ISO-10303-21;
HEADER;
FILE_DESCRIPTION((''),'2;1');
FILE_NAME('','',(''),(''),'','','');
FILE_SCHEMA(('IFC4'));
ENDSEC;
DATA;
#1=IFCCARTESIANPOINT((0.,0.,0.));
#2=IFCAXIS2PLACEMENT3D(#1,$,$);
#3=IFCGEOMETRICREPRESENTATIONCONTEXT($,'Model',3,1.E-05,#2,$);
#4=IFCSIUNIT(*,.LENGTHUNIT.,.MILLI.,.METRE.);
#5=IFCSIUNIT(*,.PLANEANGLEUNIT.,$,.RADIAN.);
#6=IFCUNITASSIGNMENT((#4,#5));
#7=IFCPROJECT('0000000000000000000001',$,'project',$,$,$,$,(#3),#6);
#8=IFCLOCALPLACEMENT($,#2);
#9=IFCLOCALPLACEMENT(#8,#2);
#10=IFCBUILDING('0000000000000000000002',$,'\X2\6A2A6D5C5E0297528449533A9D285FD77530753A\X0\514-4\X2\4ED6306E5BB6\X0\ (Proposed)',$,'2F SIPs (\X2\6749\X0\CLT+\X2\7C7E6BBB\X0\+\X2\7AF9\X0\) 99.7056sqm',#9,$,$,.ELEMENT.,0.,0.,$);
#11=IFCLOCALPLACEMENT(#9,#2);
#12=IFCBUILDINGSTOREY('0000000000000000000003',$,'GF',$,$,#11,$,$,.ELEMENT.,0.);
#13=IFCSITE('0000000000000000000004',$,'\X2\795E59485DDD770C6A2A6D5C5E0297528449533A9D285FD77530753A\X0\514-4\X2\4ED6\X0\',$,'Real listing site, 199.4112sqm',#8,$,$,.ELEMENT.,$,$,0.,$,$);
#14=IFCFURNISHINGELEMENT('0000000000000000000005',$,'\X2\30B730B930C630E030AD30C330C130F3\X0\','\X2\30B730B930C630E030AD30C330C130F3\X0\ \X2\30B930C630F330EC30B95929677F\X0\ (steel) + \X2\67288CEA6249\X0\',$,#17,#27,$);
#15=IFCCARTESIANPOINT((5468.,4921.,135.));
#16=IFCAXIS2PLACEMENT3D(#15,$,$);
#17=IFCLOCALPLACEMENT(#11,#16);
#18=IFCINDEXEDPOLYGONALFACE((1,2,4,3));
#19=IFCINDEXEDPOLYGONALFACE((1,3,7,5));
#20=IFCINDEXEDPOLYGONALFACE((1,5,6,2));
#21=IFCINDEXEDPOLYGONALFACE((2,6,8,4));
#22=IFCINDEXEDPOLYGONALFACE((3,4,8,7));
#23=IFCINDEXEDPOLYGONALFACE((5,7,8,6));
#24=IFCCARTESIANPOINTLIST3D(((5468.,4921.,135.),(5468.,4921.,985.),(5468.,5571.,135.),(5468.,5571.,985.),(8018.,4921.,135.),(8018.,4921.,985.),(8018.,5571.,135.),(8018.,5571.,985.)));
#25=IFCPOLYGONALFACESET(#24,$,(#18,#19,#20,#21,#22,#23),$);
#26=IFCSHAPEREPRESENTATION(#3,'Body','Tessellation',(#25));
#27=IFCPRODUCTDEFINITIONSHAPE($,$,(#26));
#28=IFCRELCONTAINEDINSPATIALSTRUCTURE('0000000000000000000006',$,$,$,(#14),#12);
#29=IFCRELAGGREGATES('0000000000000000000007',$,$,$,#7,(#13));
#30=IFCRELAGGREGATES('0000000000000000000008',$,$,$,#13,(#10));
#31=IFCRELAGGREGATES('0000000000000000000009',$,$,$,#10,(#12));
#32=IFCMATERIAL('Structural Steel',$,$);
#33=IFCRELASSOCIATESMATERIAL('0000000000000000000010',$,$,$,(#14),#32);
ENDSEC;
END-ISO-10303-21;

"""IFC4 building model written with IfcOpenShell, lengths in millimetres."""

from ifc_helpers import new_model, si_unit, frame, frame_2d, origin, place, context, project, spatial, rectangle, extrude, material, element, save


model = new_model("IFC4")

# Units and contexts
model_context = context("Model", 3, precision=1e-05, world=origin())
ifc_project = project(units=[si_unit("LENGTHUNIT", "METRE", prefix="MILLI"), si_unit("PLANEANGLEUNIT", "RADIAN")], contexts=[model_context])

# Site, building, storey
site_placement = place(None, origin())
site = spatial("IfcSite", under=ifc_project, at=site_placement, Name="神奈川県横浜市青葉区鴨志田町514-4他", ObjectType="Real listing site, 199.4112sqm", CompositionType="ELEMENT", RefElevation=0.0)
building_placement = place(site_placement, origin())
building = spatial("IfcBuilding", under=site, at=building_placement, Name="横浜市青葉区鴨志田町514-4他の家 (Proposed)", ObjectType="2F SIPs (杉CLT+籾殻+竹) 99.7056sqm", CompositionType="ELEMENT", ElevationOfRefHeight=0.0, ElevationOfTerrain=0.0)
storey_placement = place(building_placement, origin())
storey = spatial("IfcBuildingStorey", under=building, at=storey_placement, Name="GF", CompositionType="ELEMENT", Elevation=0.0)

# Furnishing element
ifc_material_1 = material(Name="Structural Steel")
furnishing_placement = place(storey_placement, frame((5468.0, 4921.0, 135.0)))
element("IfcFurnishingElement", 1, at=furnishing_placement, inside=storey, material=ifc_material_1, Name="システムキッチン", Description="システムキッチン ステンレス天板 (steel) + 木質扉", context=model_context, shape_type="SweptSolid", body=[
    extrude(rectangle(XDim=2550.0, YDim=650.0, at=frame_2d((1275.0, 325.0))), frame((5468.0, 4921.0, 135.0)), (0.0, 0.0, 1.0), 850.0),
])

save(model, "model.ifc")
